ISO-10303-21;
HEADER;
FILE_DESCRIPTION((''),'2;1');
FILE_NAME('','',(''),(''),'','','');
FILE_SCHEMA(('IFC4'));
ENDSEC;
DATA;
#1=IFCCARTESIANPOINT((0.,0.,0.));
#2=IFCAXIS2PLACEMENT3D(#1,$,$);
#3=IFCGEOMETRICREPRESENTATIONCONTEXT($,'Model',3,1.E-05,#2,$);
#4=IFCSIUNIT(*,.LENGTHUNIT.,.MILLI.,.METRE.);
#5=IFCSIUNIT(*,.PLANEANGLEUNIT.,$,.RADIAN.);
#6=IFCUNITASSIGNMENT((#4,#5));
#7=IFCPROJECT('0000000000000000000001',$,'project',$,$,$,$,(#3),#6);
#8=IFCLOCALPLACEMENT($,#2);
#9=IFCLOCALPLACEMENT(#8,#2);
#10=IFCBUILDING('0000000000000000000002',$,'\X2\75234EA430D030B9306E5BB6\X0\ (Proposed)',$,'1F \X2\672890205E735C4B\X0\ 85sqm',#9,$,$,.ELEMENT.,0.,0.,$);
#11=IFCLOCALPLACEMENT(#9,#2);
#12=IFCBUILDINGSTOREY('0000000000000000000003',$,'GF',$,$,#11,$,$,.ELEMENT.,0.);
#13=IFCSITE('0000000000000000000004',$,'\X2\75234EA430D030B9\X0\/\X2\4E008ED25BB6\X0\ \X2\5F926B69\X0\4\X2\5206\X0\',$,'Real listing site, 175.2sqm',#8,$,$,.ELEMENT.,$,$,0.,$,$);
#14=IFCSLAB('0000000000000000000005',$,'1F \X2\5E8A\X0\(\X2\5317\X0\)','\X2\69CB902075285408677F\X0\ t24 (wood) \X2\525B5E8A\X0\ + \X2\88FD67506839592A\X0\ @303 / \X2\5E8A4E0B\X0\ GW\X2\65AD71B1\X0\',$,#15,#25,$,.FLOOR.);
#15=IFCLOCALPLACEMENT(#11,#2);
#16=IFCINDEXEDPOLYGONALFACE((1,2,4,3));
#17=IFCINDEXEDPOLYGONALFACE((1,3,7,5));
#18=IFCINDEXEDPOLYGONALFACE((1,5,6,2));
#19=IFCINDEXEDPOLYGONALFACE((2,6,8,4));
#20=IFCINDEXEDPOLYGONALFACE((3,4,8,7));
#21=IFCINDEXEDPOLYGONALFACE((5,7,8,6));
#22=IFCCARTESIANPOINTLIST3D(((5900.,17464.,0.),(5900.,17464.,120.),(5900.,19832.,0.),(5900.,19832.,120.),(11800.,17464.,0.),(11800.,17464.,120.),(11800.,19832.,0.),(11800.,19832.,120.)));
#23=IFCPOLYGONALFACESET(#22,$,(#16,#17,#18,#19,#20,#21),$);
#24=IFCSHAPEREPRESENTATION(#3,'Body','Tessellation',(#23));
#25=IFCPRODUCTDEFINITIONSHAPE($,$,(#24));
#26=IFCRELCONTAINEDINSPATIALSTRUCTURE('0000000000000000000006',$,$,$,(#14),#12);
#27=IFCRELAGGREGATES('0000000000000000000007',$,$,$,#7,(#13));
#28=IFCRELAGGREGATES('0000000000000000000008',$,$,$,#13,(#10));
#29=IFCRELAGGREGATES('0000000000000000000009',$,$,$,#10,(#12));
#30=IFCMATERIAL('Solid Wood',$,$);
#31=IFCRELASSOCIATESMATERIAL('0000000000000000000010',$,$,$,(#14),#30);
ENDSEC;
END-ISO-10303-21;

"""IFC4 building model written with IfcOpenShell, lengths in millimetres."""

from ifc_helpers import new_model, si_unit, frame, frame_2d, origin, place, context, project, spatial, rectangle, extrude, material, element, save


model = new_model("IFC4")

# Units and contexts
model_context = context("Model", 3, precision=1e-05, world=origin())
ifc_project = project(units=[si_unit("LENGTHUNIT", "METRE", prefix="MILLI"), si_unit("PLANEANGLEUNIT", "RADIAN")], contexts=[model_context])

# Site, building, storey
site_placement = place(None, origin())
site = spatial("IfcSite", under=ifc_project, at=site_placement, Name="産交バス/一軒家 徒歩4分", ObjectType="Real listing site, 175.2sqm", CompositionType="ELEMENT", RefElevation=0.0)
building_placement = place(site_placement, origin())
building = spatial("IfcBuilding", under=site, at=building_placement, Name="産交バスの家 (Proposed)", ObjectType="1F 木造平屋 85sqm", CompositionType="ELEMENT", ElevationOfRefHeight=0.0, ElevationOfTerrain=0.0)
storey_placement = place(building_placement, origin())
storey = spatial("IfcBuildingStorey", under=building, at=storey_placement, Name="GF", CompositionType="ELEMENT", Elevation=0.0)

# Slab
ifc_material_1 = material(Name="Solid Wood")
slab_1_placement = place(storey_placement, frame((2950.0, 8732.0, 0.0)))
element("IfcSlab", 1, at=slab_1_placement, inside=storey, material=ifc_material_1, Name="1F 床(北)", Description="構造用合板 t24 (wood) 剛床 + 製材根太 @303 / 床下 GW断熱", PredefinedType="FLOOR", context=model_context, shape_type="SweptSolid", body=[
    extrude(rectangle(XDim=5900.0, YDim=2368.0, at=frame_2d((2950.0, 1184.0))), frame((2950.0, 8732.0, 0.0)), (0.0, 0.0, 1.0), 120.0),
])

save(model, "model.ifc")
